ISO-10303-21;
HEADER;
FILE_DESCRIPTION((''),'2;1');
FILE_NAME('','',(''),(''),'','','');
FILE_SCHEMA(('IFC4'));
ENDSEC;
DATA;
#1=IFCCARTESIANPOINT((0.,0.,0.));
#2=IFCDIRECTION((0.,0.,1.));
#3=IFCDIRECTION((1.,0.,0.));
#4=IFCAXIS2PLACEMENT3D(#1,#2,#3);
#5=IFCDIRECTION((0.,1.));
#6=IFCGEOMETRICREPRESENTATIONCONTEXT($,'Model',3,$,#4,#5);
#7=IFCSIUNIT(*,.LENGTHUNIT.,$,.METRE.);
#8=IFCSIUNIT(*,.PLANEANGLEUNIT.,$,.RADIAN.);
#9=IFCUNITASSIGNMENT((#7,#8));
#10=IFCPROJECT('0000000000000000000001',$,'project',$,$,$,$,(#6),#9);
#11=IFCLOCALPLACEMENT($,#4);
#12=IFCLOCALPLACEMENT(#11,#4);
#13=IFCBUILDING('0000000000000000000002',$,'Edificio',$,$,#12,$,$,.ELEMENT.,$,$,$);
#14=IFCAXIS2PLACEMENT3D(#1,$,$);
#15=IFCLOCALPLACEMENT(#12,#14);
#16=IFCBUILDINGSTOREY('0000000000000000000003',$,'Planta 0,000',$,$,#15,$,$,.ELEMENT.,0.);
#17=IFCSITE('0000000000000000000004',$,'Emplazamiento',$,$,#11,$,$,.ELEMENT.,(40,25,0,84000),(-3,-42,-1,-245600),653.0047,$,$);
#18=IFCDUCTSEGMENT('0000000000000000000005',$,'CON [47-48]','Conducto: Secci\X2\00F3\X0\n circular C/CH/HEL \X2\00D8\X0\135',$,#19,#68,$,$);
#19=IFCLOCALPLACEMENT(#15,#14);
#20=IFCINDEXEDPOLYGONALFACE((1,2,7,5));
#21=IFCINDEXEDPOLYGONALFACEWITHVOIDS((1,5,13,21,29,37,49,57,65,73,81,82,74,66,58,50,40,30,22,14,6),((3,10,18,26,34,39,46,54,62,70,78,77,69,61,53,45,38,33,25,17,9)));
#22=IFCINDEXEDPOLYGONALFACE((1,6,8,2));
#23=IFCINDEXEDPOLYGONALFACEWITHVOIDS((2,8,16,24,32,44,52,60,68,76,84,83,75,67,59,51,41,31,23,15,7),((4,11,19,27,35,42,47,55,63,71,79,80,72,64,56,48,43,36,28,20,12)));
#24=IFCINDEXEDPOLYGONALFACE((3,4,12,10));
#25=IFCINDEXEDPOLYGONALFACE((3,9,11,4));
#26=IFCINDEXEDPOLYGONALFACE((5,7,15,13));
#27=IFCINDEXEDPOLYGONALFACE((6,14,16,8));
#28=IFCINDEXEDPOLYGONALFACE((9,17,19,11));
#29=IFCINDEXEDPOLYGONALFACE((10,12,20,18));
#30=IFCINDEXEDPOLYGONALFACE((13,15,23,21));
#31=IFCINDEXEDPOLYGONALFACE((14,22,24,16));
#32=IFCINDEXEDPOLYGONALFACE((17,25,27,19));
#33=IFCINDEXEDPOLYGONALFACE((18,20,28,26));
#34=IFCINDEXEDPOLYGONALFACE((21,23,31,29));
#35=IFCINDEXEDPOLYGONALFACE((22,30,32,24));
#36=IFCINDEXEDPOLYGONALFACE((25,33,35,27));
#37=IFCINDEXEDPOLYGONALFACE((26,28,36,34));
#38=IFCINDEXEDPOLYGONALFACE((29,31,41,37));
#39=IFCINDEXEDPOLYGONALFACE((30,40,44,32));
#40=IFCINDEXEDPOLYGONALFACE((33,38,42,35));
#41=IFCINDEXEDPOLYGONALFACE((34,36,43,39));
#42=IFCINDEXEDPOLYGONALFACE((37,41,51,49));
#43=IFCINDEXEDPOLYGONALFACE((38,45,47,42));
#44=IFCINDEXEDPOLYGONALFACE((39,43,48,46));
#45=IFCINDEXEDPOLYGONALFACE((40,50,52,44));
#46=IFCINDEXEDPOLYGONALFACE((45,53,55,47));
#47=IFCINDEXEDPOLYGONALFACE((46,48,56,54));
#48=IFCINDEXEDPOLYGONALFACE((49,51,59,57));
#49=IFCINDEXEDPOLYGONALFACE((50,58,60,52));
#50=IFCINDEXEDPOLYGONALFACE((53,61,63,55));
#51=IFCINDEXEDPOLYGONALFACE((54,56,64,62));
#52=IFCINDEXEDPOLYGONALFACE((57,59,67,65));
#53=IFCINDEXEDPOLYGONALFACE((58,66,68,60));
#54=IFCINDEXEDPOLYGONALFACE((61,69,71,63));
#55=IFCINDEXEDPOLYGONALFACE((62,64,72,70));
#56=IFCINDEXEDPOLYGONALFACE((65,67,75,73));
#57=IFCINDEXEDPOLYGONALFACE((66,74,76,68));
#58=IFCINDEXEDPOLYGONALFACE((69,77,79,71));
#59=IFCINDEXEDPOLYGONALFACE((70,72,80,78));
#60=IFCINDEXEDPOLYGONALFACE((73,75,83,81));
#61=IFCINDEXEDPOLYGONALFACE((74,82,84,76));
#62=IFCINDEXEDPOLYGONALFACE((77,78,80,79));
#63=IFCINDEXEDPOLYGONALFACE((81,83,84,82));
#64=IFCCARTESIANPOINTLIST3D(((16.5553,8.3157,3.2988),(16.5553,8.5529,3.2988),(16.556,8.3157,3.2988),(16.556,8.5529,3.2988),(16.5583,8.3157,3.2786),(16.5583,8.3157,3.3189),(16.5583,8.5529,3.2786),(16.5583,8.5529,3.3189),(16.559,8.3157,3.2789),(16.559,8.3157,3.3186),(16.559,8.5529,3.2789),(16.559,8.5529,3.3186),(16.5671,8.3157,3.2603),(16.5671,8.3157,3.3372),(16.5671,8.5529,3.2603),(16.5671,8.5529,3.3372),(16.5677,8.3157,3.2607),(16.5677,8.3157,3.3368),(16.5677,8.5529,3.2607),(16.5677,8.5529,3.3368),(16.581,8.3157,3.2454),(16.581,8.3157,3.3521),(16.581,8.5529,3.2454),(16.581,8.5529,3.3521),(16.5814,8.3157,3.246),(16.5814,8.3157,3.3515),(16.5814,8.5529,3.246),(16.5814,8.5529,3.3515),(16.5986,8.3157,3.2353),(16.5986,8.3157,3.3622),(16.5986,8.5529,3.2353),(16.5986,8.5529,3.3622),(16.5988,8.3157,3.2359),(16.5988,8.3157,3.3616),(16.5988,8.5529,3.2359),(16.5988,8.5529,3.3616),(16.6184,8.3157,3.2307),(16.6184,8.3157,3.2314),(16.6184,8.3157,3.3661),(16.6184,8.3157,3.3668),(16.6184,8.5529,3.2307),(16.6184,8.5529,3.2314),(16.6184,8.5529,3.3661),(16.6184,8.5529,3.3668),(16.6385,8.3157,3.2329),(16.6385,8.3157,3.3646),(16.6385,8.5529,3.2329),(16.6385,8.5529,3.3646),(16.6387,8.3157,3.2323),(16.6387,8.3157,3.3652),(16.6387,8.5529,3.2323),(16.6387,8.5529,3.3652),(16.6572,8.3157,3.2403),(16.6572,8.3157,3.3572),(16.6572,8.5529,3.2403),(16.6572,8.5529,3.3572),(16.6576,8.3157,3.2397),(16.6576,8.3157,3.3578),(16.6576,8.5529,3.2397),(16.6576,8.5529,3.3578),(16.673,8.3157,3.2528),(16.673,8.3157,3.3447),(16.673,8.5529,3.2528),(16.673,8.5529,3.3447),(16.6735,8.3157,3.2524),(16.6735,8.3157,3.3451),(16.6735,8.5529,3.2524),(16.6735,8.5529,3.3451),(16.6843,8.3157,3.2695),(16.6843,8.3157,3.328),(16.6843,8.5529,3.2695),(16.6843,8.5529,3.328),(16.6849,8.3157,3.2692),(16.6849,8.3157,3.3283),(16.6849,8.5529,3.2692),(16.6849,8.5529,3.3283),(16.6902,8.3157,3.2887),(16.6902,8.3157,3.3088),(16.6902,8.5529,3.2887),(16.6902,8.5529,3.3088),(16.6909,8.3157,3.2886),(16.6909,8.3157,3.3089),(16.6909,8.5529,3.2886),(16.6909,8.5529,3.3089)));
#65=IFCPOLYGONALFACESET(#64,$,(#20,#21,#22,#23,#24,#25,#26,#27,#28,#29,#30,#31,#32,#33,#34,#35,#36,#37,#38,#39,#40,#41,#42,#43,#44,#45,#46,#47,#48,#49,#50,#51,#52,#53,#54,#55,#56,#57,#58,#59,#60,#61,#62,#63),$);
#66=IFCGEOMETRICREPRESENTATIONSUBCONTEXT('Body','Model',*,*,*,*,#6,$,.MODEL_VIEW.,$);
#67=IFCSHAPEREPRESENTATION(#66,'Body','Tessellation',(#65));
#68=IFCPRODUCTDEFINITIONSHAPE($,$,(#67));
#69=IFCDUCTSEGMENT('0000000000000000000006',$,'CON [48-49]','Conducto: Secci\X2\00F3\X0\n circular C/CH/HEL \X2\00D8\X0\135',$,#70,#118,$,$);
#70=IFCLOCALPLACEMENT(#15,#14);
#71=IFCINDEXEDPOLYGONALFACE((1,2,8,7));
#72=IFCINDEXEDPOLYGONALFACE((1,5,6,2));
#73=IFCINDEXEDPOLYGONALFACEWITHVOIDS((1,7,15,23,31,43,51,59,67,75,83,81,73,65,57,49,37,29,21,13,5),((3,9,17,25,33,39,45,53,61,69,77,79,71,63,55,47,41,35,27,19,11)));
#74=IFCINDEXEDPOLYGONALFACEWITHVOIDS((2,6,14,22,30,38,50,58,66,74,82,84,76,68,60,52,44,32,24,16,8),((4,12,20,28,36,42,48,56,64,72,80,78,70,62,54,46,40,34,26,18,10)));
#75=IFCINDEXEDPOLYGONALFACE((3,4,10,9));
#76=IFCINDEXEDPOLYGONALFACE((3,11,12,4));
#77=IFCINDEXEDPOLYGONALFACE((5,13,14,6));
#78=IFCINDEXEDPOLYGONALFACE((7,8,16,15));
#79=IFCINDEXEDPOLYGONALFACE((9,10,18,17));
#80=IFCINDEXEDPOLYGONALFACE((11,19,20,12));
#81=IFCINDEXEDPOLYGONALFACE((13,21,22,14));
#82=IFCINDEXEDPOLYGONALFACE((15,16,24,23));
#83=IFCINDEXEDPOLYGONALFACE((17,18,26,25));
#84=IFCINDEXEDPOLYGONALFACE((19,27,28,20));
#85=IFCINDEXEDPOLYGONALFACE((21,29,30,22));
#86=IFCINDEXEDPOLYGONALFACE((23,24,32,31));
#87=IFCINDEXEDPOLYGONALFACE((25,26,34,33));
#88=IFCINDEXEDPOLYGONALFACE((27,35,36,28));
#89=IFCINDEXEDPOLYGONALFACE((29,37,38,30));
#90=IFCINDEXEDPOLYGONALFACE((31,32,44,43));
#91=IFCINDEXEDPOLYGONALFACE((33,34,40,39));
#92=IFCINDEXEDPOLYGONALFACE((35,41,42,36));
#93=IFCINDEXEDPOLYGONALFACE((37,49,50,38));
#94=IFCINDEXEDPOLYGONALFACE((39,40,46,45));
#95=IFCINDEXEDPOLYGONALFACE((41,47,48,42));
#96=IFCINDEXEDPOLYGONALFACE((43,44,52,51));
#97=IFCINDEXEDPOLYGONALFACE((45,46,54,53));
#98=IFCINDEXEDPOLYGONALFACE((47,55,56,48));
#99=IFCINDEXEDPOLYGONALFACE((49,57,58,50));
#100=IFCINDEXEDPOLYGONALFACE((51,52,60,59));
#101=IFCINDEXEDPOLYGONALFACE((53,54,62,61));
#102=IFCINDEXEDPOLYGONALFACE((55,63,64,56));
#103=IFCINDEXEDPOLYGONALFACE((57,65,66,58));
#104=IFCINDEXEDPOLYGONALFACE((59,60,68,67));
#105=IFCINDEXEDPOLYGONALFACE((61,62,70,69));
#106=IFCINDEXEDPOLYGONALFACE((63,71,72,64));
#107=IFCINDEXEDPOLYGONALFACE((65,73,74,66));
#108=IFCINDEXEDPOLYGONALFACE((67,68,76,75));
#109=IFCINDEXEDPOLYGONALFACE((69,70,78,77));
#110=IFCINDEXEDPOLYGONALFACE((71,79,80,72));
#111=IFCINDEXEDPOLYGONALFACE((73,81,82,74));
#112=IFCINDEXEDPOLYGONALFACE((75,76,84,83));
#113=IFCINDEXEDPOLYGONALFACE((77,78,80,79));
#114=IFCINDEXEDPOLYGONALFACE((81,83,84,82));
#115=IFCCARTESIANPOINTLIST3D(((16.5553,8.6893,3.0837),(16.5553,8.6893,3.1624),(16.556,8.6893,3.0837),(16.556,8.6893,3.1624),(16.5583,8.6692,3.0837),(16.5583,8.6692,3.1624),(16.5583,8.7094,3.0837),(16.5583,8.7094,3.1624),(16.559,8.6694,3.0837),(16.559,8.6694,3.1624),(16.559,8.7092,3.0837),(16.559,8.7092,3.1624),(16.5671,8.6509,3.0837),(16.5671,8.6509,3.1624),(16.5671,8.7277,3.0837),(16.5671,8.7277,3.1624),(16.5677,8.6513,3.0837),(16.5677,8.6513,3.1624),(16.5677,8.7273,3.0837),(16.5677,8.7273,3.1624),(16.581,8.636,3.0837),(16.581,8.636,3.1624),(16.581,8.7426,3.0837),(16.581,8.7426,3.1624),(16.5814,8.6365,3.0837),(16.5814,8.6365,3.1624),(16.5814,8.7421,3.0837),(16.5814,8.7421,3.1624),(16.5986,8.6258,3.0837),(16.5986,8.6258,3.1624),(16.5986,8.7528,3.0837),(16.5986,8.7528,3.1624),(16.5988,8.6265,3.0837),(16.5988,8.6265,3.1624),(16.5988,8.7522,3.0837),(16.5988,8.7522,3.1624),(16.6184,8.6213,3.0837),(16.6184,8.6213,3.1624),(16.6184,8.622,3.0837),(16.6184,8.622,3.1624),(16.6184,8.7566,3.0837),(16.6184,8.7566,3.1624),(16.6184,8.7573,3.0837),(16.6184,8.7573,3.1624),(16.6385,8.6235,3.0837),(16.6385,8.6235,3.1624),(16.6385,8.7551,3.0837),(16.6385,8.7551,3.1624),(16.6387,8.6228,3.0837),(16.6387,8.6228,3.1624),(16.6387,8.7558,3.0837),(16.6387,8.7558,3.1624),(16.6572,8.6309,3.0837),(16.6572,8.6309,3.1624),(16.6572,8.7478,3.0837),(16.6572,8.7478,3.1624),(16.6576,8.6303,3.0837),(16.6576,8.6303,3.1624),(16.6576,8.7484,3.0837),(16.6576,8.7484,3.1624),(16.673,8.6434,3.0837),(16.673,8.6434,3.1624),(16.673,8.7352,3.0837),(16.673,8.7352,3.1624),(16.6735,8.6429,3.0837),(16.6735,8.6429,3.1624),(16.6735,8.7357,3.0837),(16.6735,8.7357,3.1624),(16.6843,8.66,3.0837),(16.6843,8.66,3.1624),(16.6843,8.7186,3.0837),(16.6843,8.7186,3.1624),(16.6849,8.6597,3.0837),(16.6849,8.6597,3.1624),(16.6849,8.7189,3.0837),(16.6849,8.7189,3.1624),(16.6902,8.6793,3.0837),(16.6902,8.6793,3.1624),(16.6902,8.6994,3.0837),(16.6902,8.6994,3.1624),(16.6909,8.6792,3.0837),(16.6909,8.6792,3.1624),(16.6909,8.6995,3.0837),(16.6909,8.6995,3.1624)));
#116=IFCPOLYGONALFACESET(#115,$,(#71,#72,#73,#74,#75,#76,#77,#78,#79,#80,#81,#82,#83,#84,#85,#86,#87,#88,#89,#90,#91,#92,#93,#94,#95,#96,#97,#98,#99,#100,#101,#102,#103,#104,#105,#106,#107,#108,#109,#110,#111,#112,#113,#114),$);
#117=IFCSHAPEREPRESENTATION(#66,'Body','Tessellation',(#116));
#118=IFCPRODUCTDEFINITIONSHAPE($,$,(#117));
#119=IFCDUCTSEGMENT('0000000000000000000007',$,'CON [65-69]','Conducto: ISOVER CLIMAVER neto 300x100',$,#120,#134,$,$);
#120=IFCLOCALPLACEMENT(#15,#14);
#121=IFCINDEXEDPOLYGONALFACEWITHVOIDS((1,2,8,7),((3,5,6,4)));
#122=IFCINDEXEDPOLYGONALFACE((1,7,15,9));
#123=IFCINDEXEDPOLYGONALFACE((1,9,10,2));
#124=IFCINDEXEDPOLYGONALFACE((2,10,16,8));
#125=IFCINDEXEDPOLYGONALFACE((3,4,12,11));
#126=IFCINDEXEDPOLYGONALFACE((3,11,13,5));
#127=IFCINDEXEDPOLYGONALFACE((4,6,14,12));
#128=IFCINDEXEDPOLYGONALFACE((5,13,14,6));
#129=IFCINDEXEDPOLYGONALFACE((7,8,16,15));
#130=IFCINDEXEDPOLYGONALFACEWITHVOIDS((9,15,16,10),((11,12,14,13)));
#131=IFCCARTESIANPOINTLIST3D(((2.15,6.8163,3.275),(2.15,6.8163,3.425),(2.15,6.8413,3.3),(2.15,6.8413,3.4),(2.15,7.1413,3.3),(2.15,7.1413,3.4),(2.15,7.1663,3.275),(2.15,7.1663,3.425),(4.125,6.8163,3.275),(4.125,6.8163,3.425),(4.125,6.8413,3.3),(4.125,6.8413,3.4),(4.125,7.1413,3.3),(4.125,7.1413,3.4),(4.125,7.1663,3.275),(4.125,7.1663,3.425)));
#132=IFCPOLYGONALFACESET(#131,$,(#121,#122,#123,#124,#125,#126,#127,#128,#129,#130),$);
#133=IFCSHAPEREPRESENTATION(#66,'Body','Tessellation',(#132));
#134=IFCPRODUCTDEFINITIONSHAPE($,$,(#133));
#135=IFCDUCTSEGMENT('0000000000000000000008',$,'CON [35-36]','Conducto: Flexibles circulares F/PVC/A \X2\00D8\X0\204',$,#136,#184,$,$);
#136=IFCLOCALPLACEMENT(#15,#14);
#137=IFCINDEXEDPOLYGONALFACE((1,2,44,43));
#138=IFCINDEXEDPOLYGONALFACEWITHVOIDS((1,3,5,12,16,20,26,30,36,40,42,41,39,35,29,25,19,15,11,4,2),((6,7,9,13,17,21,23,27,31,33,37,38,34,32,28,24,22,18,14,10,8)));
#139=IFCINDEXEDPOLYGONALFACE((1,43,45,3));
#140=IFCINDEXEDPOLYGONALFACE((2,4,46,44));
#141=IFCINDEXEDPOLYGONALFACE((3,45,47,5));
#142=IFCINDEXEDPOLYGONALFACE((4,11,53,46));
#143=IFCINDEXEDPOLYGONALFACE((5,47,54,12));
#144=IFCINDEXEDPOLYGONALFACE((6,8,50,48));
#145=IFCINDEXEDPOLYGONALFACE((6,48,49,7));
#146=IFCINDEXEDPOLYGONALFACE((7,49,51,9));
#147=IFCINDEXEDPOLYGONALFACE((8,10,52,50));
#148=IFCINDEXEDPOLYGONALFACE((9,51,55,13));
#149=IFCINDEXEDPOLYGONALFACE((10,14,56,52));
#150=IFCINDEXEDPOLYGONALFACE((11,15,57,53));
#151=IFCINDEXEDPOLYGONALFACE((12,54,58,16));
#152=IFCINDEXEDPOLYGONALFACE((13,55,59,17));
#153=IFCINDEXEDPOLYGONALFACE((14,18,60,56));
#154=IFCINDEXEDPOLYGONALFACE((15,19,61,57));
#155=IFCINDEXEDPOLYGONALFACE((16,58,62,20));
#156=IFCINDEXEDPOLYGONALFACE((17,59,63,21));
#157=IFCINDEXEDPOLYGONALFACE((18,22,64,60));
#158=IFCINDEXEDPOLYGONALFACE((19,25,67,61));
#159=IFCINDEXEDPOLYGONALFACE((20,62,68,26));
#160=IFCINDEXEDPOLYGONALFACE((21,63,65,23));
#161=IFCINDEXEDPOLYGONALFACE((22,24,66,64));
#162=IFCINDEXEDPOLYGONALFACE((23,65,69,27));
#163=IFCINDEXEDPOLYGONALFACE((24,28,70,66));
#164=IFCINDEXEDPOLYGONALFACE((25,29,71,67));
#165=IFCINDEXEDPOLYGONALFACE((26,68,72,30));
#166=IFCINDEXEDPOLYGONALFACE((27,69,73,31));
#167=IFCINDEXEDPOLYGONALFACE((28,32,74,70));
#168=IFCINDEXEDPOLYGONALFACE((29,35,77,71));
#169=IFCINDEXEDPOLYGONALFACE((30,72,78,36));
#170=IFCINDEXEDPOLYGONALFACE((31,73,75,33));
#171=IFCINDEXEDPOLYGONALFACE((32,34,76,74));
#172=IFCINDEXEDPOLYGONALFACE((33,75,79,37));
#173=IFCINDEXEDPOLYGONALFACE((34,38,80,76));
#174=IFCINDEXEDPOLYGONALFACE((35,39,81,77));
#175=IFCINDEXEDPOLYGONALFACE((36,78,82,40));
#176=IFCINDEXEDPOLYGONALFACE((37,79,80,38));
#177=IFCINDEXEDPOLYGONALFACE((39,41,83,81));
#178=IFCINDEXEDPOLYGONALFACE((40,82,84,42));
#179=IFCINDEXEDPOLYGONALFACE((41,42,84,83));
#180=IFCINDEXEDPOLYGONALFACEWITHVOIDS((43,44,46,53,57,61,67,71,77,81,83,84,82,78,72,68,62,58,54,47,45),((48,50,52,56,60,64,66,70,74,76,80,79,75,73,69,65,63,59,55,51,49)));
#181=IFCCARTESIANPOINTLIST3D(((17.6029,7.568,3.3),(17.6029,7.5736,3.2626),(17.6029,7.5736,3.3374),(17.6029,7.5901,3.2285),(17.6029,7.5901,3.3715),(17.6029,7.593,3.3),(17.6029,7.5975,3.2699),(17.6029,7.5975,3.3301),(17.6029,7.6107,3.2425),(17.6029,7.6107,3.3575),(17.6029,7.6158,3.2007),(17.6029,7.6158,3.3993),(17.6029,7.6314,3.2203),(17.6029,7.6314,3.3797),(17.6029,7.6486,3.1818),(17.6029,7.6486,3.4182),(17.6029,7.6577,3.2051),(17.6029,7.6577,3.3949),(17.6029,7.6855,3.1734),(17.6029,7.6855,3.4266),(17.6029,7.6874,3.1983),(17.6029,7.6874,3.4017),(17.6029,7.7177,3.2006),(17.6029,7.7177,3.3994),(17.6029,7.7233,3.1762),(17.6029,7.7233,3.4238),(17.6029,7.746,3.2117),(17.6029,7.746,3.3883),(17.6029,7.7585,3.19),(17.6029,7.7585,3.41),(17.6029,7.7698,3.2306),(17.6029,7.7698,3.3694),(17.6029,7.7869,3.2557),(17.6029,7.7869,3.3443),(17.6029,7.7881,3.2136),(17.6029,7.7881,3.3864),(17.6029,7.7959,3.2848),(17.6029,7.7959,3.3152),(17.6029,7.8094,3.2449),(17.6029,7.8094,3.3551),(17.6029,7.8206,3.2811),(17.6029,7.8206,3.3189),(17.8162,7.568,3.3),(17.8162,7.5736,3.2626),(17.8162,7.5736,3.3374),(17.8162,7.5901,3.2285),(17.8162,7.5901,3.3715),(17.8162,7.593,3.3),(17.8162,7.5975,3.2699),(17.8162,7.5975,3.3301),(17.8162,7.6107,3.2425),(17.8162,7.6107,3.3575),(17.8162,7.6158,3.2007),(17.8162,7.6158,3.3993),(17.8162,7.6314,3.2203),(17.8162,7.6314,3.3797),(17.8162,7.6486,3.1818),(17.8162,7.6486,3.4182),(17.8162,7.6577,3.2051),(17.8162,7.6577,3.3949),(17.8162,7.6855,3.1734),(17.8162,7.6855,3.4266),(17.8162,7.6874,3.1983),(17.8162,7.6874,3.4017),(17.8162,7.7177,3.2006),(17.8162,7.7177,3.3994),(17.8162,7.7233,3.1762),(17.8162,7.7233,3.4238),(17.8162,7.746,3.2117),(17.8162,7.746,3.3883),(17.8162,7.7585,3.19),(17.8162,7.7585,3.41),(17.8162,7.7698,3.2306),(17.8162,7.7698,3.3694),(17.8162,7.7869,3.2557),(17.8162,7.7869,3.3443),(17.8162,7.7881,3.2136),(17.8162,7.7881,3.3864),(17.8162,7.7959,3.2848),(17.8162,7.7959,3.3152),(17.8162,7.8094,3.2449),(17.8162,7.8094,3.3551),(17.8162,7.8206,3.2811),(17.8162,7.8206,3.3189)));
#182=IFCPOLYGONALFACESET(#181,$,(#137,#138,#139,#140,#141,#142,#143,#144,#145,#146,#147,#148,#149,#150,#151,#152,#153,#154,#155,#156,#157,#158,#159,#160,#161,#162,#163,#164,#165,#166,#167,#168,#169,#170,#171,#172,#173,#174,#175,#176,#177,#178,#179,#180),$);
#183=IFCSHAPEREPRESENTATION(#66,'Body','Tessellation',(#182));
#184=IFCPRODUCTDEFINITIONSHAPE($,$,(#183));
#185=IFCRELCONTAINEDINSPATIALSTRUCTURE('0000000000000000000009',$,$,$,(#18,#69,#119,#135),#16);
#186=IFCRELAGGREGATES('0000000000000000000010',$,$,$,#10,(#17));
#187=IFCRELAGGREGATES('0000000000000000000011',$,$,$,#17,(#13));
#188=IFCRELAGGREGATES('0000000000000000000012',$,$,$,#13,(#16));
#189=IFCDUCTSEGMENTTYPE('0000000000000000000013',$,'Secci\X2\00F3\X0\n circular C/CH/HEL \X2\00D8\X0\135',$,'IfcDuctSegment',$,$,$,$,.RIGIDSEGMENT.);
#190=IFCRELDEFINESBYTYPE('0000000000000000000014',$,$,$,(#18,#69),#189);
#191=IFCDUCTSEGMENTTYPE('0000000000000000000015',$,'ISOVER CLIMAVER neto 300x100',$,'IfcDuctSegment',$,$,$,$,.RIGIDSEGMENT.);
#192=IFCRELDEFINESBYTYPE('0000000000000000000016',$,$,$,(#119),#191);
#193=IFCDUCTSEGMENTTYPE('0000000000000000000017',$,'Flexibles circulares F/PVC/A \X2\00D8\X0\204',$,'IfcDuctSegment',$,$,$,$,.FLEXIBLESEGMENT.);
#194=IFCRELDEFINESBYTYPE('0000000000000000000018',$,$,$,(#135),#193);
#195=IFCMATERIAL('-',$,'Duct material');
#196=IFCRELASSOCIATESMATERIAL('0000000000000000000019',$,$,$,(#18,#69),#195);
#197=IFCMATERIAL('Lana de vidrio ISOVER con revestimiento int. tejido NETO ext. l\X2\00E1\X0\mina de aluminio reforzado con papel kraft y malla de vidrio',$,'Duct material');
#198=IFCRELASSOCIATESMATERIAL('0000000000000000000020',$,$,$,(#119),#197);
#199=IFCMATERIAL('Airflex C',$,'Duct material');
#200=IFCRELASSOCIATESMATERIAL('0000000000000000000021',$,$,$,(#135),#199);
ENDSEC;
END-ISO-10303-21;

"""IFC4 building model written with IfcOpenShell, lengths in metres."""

from ifc_helpers import new_model, si_unit, direction, frame, origin, origin_with_axes, origin_2d_with_axis, place, context, subcontext, project, spatial, hollow_rectangle, hollow_circle, extrude, material, type_object, element, save


model = new_model("IFC4")

# Units and contexts
model_context = context("Model", 3, world=origin_with_axes(), true_north=direction((0.0, 1.0)))
body_context = subcontext(model_context, "Body", "Model", "MODEL_VIEW")
ifc_project = project(units=[si_unit("LENGTHUNIT", "METRE"), si_unit("PLANEANGLEUNIT", "RADIAN")], contexts=[model_context])

# Site, building, storey
site_placement = place(None, origin_with_axes())
site = spatial("IfcSite", under=ifc_project, at=site_placement, Name="Emplazamiento", CompositionType="ELEMENT", RefLatitude=(40, 25, 0, 84000), RefLongitude=(-3, -42, -1, -245600), RefElevation=653.0047)
building_placement = place(site_placement, origin_with_axes())
building = spatial("IfcBuilding", under=site, at=building_placement, Name="Edificio", CompositionType="ELEMENT")
storey_placement = place(building_placement, origin())
storey = spatial("IfcBuildingStorey", under=building, at=storey_placement, Name="Planta 0,000", CompositionType="ELEMENT", Elevation=0.0)

# Shared definitions
ifc_material_1 = material(Name="-", Category="Duct material")

# Shared definitions
ifc_material_2 = material(Name="Lana de vidrio ISOVER con revestimiento int. tejido NETO ext. lámina de aluminio reforzado con papel kraft y malla de vidrio", Category="Duct material")

# Duct segments
duct_segment_type_1 = type_object("IfcDuctSegmentType", Name="Sección circular C/CH/HEL Ø135", ApplicableOccurrence="IfcDuctSegment", PredefinedType="RIGIDSEGMENT")
duct_segment_1_placement = place(storey_placement, origin_with_axes())
element("IfcDuctSegment", 1, at=duct_segment_1_placement, inside=storey, type_object=duct_segment_type_1, material=ifc_material_1, Name="CON [47-48]", Description="Conducto: Sección circular C/CH/HEL Ø135", context=body_context, shape_type="SweptSolid", body=[
    extrude(hollow_circle(Radius=0.0682, WallThickness=0.0007, at=origin_2d_with_axis()), frame((16.6235, 8.3157, 3.2988), z_axis=(0.0, 1.0, 0.0), x_axis=(-1.0, 0.0, 0.0)), (0.0, 0.0, 1.0), 0.2372),
])
duct_segment_2_placement = place(storey_placement, origin_with_axes())
element("IfcDuctSegment", 2, at=duct_segment_2_placement, inside=storey, type_object=duct_segment_type_1, material=ifc_material_1, Name="CON [48-49]", Description="Conducto: Sección circular C/CH/HEL Ø135", context=body_context, shape_type="SweptSolid", body=[
    extrude(hollow_circle(Radius=0.0682, WallThickness=0.0007, at=origin_2d_with_axis()), frame((16.6235, 8.6893, 3.1624), z_axis=(0.0, 0.0, -1.0), x_axis=(-1.0, 0.0, 0.0)), (0.0, 0.0, 1.0), 0.0786),
])
duct_segment_type_2 = type_object("IfcDuctSegmentType", Name="ISOVER CLIMAVER neto 300x100", ApplicableOccurrence="IfcDuctSegment", PredefinedType="RIGIDSEGMENT")
duct_segment_3_placement = place(storey_placement, origin_with_axes())
element("IfcDuctSegment", 3, at=duct_segment_3_placement, inside=storey, type_object=duct_segment_type_2, material=ifc_material_2, Name="CON [65-69]", Description="Conducto: ISOVER CLIMAVER neto 300x100", context=body_context, shape_type="SweptSolid", body=[
    extrude(hollow_rectangle(XDim=0.35, YDim=0.15, WallThickness=0.025, at=origin_2d_with_axis()), frame((4.125, 6.9913, 3.35), z_axis=(-1.0, 0.0, 0.0), x_axis=(0.0, -1.0, 0.0)), (0.0, 0.0, 1.0), 1.975),
])
ifc_material_3 = material(Name="Airflex C", Category="Duct material")
duct_segment_type_3 = type_object("IfcDuctSegmentType", Name="Flexibles circulares F/PVC/A Ø204", ApplicableOccurrence="IfcDuctSegment", PredefinedType="FLEXIBLESEGMENT")
duct_segment_4_placement = place(storey_placement, origin_with_axes())
element("IfcDuctSegment", 4, at=duct_segment_4_placement, inside=storey, type_object=duct_segment_type_3, material=ifc_material_3, Name="CON [35-36]", Description="Conducto: Flexibles circulares F/PVC/A Ø204", context=body_context, shape_type="SweptSolid", body=[
    extrude(hollow_circle(Radius=0.127, WallThickness=0.025, at=origin_2d_with_axis()), frame((17.8162, 7.695, 3.3), z_axis=(-1.0, 0.0, 0.0), x_axis=(0.0, -1.0, 0.0)), (0.0, 0.0, 1.0), 0.2133),
])

save(model, "model.ifc")
